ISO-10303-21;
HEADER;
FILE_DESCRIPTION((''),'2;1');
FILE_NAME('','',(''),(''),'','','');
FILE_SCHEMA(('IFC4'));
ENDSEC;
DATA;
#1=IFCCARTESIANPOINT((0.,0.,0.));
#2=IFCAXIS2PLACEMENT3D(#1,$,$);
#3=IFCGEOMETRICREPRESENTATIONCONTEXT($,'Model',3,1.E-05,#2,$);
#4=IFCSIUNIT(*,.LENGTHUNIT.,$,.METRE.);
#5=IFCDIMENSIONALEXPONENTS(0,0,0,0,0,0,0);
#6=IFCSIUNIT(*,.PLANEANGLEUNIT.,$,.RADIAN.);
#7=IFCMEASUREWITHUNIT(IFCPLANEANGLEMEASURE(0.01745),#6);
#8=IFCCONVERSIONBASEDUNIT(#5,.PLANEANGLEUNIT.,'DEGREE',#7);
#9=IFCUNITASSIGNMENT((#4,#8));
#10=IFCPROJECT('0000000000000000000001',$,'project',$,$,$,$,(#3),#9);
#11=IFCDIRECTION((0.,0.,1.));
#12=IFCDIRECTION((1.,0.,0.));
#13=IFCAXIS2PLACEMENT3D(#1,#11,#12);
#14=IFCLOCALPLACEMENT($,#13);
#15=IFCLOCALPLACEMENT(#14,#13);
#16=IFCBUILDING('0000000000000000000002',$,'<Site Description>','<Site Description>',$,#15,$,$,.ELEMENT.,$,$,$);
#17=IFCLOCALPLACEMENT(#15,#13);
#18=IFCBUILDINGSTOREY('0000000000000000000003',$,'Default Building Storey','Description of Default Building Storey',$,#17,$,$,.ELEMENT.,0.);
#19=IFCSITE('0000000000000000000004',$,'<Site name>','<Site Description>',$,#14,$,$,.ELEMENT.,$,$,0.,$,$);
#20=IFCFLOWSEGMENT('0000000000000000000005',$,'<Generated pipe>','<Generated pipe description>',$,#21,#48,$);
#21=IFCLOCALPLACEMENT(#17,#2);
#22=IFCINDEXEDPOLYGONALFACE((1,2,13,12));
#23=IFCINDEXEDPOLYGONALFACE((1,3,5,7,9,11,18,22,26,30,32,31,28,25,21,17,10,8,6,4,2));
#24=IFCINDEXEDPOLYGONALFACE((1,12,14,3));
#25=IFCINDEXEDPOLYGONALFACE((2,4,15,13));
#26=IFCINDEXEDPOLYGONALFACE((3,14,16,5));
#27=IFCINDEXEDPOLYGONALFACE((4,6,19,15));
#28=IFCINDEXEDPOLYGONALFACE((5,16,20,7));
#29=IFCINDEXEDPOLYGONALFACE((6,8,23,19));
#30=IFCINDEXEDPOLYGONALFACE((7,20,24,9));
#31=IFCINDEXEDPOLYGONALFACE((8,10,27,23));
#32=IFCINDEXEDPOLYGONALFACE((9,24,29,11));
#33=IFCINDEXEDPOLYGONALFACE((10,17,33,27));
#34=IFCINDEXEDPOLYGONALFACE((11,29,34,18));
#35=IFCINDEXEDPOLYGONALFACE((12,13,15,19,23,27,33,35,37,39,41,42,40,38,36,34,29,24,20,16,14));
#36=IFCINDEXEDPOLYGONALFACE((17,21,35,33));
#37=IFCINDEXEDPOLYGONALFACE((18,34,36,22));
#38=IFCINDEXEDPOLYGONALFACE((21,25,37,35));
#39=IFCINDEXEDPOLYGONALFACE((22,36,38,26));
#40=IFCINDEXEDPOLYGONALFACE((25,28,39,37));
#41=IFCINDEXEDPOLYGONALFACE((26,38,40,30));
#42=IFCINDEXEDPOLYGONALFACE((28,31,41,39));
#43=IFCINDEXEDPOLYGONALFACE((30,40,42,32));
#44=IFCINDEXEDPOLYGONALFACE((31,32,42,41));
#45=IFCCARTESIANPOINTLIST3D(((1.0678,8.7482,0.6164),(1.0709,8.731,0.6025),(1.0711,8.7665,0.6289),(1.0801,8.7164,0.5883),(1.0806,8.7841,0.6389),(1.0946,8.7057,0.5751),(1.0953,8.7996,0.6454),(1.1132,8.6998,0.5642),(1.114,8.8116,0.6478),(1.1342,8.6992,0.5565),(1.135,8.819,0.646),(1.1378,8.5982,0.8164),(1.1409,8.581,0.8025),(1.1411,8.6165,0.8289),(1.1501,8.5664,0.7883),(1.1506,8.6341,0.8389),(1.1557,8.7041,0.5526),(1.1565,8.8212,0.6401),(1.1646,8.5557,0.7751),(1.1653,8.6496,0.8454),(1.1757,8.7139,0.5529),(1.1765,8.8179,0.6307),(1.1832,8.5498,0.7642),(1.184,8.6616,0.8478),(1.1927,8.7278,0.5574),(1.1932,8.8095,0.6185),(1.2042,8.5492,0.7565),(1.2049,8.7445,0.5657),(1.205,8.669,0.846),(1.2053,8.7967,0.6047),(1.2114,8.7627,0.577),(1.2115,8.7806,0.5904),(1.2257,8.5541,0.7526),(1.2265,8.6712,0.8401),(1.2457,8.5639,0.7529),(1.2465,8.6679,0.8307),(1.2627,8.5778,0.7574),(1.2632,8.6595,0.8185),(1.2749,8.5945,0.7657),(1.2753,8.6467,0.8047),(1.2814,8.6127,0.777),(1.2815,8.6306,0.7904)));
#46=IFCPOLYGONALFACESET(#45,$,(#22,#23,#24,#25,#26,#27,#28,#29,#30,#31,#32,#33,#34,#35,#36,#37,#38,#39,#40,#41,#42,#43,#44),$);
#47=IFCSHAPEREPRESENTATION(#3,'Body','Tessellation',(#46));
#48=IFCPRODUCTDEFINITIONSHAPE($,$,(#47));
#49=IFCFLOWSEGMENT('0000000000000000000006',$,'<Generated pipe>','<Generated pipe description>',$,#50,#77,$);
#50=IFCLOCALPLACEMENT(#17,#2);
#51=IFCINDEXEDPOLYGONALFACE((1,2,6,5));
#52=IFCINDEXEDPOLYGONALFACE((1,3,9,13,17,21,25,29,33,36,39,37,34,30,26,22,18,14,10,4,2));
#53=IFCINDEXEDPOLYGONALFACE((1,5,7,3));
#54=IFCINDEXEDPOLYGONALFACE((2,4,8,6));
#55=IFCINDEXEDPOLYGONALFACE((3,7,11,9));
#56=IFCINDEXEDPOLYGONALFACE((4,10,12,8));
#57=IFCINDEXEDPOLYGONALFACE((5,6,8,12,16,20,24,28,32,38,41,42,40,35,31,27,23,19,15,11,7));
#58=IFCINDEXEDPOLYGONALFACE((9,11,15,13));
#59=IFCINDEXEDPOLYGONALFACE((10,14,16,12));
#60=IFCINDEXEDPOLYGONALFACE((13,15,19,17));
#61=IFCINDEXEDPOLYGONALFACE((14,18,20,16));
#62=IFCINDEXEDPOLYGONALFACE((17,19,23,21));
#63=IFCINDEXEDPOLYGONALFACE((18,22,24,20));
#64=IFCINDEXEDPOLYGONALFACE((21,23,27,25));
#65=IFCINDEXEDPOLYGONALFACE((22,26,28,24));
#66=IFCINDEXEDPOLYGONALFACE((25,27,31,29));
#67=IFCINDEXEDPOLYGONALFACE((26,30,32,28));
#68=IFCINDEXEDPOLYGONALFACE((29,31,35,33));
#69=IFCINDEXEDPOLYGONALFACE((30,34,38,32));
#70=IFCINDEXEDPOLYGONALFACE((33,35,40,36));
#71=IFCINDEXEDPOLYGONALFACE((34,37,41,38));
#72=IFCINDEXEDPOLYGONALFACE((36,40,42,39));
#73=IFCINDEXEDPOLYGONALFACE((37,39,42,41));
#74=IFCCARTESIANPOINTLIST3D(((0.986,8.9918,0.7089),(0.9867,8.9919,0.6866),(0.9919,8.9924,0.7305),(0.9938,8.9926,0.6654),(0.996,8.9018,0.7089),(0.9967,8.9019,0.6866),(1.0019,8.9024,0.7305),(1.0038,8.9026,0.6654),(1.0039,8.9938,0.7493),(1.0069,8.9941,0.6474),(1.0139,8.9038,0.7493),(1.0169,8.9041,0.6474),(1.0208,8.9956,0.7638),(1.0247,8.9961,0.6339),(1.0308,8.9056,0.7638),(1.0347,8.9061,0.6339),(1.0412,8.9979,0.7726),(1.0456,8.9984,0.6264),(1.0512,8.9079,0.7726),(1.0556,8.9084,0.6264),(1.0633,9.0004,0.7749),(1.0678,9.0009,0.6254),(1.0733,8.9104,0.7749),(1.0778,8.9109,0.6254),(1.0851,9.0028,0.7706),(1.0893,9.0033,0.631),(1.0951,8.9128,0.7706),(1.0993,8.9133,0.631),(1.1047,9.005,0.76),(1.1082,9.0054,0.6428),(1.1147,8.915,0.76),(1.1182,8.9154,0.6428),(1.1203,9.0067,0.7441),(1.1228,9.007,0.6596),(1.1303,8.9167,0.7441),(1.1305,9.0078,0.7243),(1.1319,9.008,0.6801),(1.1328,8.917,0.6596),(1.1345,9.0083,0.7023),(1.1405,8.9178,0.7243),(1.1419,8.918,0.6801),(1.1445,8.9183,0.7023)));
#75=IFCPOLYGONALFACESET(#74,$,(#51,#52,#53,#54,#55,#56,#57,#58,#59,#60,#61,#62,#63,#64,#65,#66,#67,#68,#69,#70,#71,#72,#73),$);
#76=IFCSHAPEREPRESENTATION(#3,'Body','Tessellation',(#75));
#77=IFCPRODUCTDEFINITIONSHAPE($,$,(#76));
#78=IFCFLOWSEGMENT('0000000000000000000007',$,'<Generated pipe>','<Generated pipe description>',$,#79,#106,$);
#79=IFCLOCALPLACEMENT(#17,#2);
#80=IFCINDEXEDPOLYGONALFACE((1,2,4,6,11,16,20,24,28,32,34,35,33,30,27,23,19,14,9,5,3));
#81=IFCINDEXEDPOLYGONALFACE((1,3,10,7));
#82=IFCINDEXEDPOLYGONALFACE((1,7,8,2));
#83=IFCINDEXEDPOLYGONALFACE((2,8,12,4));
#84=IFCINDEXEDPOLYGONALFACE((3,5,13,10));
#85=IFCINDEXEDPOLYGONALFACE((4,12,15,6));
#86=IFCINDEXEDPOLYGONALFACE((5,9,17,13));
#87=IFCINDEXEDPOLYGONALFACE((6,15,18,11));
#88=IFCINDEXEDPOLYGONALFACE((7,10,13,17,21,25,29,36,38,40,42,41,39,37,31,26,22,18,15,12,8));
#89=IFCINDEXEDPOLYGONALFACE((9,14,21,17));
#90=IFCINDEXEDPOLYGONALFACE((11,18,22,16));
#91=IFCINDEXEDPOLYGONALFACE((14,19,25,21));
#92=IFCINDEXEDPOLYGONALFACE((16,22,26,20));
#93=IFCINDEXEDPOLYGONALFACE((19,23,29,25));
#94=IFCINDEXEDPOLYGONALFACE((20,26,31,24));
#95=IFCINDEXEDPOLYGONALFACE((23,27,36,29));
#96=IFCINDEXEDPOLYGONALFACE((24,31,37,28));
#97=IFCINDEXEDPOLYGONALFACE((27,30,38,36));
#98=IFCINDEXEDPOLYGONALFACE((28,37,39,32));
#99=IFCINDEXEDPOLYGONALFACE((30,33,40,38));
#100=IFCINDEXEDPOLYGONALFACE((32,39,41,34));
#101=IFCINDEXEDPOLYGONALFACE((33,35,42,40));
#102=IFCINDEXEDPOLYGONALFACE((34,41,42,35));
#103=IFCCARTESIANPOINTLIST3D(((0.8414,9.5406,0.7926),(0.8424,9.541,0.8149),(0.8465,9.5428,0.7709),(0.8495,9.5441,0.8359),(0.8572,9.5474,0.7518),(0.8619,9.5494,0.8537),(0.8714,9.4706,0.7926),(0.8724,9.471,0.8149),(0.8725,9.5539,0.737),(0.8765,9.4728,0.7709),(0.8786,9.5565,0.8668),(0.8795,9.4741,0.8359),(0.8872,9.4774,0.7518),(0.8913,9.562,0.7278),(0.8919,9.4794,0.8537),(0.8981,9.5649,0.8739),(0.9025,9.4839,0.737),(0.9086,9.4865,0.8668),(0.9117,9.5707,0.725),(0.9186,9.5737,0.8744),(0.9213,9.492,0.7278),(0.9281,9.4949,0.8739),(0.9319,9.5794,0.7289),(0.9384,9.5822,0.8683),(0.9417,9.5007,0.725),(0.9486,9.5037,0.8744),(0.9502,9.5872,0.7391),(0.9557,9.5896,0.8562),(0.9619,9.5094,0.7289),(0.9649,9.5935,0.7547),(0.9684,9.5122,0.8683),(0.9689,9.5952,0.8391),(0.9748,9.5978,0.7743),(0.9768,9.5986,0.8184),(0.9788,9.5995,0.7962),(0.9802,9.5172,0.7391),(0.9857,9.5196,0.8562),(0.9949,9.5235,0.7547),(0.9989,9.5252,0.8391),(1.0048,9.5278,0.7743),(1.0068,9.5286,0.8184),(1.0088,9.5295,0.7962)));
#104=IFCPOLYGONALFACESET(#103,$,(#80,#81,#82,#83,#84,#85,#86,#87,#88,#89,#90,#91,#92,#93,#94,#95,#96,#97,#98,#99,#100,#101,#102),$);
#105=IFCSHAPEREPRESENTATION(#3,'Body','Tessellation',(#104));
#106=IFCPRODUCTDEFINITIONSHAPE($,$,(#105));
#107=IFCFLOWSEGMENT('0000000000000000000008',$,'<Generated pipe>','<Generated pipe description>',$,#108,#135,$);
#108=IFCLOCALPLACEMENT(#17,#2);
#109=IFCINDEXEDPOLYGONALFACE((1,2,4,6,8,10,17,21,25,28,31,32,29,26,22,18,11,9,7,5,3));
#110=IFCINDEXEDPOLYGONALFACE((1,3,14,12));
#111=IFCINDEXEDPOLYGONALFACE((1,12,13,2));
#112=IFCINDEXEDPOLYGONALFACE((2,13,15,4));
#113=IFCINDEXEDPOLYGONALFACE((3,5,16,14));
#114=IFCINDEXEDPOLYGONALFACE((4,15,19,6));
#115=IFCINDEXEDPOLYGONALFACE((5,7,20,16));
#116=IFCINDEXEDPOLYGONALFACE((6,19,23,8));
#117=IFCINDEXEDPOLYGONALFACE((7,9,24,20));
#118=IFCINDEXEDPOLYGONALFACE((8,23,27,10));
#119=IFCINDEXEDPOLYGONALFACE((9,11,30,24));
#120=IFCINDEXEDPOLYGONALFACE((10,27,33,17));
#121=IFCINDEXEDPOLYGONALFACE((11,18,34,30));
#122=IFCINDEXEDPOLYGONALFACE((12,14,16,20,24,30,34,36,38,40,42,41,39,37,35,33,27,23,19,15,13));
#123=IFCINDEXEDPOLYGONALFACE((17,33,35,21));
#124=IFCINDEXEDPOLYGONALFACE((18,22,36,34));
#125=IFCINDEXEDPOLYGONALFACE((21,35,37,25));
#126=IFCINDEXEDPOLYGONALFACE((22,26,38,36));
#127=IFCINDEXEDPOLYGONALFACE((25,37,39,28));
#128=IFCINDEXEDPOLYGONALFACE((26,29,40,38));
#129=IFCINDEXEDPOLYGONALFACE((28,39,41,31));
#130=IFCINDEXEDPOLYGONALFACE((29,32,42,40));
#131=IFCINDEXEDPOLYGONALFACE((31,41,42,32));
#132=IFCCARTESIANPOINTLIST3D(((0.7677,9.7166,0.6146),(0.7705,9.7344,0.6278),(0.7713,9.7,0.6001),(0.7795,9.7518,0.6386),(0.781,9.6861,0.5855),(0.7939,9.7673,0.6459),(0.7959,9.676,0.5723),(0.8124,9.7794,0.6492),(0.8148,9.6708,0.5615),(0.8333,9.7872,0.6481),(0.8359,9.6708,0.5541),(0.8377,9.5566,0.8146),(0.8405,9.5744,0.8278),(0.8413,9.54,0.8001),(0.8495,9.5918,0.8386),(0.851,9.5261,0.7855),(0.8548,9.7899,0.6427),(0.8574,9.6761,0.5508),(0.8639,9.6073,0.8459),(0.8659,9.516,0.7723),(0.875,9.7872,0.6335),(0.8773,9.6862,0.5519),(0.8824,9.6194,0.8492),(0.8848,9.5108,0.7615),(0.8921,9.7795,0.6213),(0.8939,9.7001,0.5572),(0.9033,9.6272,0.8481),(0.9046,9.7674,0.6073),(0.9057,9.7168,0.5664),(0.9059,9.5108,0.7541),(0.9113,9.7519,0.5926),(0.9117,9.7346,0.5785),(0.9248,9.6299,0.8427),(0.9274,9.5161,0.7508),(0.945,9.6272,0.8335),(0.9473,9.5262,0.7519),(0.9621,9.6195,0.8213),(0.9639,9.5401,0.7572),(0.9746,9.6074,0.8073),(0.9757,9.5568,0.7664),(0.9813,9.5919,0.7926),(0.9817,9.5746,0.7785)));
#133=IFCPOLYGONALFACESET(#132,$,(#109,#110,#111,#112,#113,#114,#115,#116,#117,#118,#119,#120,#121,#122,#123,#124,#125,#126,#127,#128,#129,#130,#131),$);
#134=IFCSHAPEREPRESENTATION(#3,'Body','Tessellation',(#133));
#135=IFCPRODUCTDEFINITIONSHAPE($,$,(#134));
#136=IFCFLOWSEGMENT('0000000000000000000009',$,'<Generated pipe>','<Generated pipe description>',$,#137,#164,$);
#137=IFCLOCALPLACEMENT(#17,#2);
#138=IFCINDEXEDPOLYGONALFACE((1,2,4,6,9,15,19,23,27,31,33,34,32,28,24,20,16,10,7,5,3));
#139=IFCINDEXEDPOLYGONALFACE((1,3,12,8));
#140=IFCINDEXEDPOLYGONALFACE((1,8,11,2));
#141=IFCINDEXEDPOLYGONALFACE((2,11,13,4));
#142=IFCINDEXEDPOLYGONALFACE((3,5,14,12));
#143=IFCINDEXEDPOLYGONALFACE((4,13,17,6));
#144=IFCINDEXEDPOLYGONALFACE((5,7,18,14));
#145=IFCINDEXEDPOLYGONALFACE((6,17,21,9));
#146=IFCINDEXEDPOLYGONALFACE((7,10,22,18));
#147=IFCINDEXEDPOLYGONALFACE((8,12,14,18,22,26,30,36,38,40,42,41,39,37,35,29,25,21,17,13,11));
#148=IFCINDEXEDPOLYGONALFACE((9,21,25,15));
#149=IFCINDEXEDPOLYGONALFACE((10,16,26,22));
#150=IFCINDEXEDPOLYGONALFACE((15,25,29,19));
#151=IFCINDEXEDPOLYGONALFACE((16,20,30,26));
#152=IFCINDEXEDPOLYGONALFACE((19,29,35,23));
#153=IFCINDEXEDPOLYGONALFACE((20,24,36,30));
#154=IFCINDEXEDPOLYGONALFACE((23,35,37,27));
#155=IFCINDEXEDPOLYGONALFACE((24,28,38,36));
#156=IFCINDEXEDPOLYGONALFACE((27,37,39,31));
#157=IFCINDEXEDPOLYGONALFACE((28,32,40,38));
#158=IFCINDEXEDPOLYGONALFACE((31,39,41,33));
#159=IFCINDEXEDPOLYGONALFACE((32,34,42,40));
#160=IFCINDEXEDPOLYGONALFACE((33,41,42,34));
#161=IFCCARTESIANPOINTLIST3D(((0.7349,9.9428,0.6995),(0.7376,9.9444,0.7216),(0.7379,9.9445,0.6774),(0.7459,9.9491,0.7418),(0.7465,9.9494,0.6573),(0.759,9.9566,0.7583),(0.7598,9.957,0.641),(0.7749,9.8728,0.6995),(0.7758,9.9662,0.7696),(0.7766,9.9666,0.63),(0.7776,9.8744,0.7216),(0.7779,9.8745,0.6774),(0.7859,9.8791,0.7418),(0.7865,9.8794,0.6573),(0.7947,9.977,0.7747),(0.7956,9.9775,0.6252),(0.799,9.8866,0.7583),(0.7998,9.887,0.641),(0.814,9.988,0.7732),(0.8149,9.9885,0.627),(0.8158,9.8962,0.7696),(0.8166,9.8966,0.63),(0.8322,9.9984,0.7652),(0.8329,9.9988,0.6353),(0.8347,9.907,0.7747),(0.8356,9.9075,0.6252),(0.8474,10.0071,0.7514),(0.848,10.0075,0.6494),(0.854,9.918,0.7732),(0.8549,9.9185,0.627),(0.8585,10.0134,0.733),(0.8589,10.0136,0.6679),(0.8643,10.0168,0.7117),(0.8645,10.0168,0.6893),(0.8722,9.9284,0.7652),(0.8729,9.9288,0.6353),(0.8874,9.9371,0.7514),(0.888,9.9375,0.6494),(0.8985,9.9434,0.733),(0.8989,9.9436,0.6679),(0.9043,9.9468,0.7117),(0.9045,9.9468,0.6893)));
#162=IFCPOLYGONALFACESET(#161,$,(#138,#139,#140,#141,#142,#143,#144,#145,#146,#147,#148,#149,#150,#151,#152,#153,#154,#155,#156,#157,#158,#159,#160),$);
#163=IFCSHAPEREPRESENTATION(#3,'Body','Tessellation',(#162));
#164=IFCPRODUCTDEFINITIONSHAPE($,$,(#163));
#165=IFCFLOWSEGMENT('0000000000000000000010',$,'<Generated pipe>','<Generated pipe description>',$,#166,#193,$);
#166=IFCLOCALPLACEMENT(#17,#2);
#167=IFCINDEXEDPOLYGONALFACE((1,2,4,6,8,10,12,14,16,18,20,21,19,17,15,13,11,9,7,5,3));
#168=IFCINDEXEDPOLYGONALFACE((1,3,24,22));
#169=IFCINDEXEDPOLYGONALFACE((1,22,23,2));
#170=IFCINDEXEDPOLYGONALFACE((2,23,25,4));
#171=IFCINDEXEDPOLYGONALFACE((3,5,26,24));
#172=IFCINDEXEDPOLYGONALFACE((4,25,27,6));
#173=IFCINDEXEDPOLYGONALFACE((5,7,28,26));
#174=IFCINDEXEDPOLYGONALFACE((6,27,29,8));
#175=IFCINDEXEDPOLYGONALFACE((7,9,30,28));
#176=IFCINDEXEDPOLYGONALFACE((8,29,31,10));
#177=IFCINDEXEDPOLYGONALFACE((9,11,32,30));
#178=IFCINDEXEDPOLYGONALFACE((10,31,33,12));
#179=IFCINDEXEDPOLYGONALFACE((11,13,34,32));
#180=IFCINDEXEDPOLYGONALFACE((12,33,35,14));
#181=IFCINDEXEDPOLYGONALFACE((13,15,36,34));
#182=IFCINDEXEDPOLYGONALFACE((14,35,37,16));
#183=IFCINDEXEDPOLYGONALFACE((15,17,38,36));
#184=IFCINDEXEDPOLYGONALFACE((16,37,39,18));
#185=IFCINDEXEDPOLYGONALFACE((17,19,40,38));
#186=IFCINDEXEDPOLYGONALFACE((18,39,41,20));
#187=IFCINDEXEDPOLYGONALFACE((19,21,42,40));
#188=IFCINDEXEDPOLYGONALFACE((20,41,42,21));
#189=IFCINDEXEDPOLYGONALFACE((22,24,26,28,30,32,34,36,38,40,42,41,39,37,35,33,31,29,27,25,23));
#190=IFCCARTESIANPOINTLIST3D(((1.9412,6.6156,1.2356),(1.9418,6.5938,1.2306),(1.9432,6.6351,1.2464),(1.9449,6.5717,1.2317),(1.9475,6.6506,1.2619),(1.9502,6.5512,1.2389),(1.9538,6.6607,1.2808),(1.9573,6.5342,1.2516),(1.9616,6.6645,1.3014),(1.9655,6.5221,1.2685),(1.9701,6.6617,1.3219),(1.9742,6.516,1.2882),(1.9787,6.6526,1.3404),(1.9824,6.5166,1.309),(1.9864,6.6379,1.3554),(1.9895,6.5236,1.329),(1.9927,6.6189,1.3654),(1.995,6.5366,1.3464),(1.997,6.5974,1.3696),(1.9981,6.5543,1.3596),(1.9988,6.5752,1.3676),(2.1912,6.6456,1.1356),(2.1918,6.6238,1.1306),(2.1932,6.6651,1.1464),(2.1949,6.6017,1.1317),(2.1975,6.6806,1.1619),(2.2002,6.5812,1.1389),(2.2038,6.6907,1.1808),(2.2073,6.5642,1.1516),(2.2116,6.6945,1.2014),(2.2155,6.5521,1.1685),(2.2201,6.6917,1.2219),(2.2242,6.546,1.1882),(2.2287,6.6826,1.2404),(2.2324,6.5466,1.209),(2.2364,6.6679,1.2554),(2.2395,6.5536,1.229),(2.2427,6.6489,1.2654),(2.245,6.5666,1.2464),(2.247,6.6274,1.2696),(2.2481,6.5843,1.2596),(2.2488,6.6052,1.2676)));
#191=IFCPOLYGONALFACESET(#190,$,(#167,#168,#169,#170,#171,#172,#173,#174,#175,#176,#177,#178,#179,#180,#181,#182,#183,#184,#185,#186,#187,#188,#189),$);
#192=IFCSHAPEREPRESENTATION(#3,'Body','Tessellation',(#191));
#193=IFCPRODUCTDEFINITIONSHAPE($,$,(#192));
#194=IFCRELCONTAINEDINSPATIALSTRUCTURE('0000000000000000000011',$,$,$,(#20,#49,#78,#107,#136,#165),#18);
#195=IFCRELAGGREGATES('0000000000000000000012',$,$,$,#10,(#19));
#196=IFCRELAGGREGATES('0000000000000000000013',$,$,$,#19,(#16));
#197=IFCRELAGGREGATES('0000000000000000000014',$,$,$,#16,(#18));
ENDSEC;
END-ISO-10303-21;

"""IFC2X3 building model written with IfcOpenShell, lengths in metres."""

from ifc_helpers import new_model, entity, si_unit, converted_unit, frame, origin, origin_with_axes, origin_2d_with_axis, place, context, project, spatial, circle, extrude, element, save


model = new_model("IFC2X3")

# Units and contexts
model_context = context("Model", 3, precision=1e-05, world=origin())
ifc_project = project(units=[si_unit("LENGTHUNIT", "METRE"), converted_unit("PLANEANGLEUNIT", "DEGREE", entity("IfcPlaneAngleMeasure", 0.01745), si_unit("PLANEANGLEUNIT", "RADIAN"), dimensions=[0, 0, 0, 0, 0, 0, 0])], contexts=[model_context])

# Site, building, storey
site_placement = place(None, origin_with_axes())
site = spatial("IfcSite", under=ifc_project, at=site_placement, Name="<Site name>", Description="<Site Description>", CompositionType="ELEMENT", RefElevation=0.0)
building_placement = place(site_placement, origin_with_axes())
building = spatial("IfcBuilding", under=site, at=building_placement, Name="<Site Description>", Description="<Site Description>", CompositionType="ELEMENT")
storey_placement = place(building_placement, origin_with_axes())
storey = spatial("IfcBuildingStorey", under=building, at=storey_placement, Name="Default Building Storey", Description="Description of Default Building Storey", CompositionType="ELEMENT", Elevation=0.0)

# Flow segments
flow_segment_1_placement = place(storey_placement, frame((1.21, 8.61, 0.8), z_axis=(-0.26963, 0.577778, -0.770371), x_axis=(-0.066262, 0.786972, 0.613421)))
element("IfcFlowSegment", 1, at=flow_segment_1_placement, inside=storey, Name="<Generated pipe>", Description="<Generated pipe description>", context=model_context, shape_type="SweptSolid", body=[
    extrude(circle(Radius=0.075, at=origin_2d_with_axis()), origin_with_axes(), (0.0, 0.0, 1.0), 0.2596),
])
flow_segment_2_placement = place(storey_placement, frame((1.07, 8.91, 0.7), z_axis=(-0.110432, 0.993884, 0.0), x_axis=(0.940474, 0.104497, 0.323403)))
element("IfcFlowSegment", 2, at=flow_segment_2_placement, inside=storey, Name="<Generated pipe>", Description="<Generated pipe description>", context=model_context, shape_type="SweptSolid", body=[
    extrude(circle(Radius=0.075, at=origin_2d_with_axis()), origin_with_axes(), (0.0, 0.0, 1.0), 0.0906),
])
flow_segment_3_placement = place(storey_placement, frame((0.94, 9.5, 0.8), z_axis=(-0.393919, 0.919145, 0.0), x_axis=(0.890918, 0.381822, 0.24592)))
element("IfcFlowSegment", 3, at=flow_segment_3_placement, inside=storey, Name="<Generated pipe>", Description="<Generated pipe description>", context=model_context, shape_type="SweptSolid", body=[
    extrude(circle(Radius=0.075, at=origin_2d_with_axis()), origin_with_axes(), (0.0, 0.0, 1.0), 0.0762),
])
flow_segment_4_placement = place(storey_placement, frame((0.91, 9.57, 0.8), z_axis=(-0.263635, 0.602595, -0.753244), x_axis=(0.197764, 0.798047, 0.56922)))
element("IfcFlowSegment", 4, at=flow_segment_4_placement, inside=storey, Name="<Generated pipe>", Description="<Generated pipe description>", context=model_context, shape_type="SweptSolid", body=[
    extrude(circle(Radius=0.075, at=origin_2d_with_axis()), origin_with_axes(), (0.0, 0.0, 1.0), 0.2655),
])
flow_segment_5_placement = place(storey_placement, frame((0.84, 9.91, 0.7), z_axis=(-0.496139, 0.868243, 0.0), x_axis=(0.4289, 0.245085, 0.86947)))
element("IfcFlowSegment", 5, at=flow_segment_5_placement, inside=storey, Name="<Generated pipe>", Description="<Generated pipe description>", context=model_context, shape_type="SweptSolid", body=[
    extrude(circle(Radius=0.075, at=origin_2d_with_axis()), origin_with_axes(), (0.0, 0.0, 1.0), 0.0806),
])
flow_segment_6_placement = place(storey_placement, frame((2.22, 6.62, 1.2), z_axis=(-0.922767, -0.110732, 0.369107), x_axis=(0.302519, 0.385173, 0.871851)))
element("IfcFlowSegment", 6, at=flow_segment_6_placement, inside=storey, Name="<Generated pipe>", Description="<Generated pipe description>", context=model_context, shape_type="SweptSolid", body=[
    extrude(circle(Radius=0.075, at=origin_2d_with_axis()), origin_with_axes(), (0.0, 0.0, 1.0), 0.2709),
])

save(model, "model.ifc")
